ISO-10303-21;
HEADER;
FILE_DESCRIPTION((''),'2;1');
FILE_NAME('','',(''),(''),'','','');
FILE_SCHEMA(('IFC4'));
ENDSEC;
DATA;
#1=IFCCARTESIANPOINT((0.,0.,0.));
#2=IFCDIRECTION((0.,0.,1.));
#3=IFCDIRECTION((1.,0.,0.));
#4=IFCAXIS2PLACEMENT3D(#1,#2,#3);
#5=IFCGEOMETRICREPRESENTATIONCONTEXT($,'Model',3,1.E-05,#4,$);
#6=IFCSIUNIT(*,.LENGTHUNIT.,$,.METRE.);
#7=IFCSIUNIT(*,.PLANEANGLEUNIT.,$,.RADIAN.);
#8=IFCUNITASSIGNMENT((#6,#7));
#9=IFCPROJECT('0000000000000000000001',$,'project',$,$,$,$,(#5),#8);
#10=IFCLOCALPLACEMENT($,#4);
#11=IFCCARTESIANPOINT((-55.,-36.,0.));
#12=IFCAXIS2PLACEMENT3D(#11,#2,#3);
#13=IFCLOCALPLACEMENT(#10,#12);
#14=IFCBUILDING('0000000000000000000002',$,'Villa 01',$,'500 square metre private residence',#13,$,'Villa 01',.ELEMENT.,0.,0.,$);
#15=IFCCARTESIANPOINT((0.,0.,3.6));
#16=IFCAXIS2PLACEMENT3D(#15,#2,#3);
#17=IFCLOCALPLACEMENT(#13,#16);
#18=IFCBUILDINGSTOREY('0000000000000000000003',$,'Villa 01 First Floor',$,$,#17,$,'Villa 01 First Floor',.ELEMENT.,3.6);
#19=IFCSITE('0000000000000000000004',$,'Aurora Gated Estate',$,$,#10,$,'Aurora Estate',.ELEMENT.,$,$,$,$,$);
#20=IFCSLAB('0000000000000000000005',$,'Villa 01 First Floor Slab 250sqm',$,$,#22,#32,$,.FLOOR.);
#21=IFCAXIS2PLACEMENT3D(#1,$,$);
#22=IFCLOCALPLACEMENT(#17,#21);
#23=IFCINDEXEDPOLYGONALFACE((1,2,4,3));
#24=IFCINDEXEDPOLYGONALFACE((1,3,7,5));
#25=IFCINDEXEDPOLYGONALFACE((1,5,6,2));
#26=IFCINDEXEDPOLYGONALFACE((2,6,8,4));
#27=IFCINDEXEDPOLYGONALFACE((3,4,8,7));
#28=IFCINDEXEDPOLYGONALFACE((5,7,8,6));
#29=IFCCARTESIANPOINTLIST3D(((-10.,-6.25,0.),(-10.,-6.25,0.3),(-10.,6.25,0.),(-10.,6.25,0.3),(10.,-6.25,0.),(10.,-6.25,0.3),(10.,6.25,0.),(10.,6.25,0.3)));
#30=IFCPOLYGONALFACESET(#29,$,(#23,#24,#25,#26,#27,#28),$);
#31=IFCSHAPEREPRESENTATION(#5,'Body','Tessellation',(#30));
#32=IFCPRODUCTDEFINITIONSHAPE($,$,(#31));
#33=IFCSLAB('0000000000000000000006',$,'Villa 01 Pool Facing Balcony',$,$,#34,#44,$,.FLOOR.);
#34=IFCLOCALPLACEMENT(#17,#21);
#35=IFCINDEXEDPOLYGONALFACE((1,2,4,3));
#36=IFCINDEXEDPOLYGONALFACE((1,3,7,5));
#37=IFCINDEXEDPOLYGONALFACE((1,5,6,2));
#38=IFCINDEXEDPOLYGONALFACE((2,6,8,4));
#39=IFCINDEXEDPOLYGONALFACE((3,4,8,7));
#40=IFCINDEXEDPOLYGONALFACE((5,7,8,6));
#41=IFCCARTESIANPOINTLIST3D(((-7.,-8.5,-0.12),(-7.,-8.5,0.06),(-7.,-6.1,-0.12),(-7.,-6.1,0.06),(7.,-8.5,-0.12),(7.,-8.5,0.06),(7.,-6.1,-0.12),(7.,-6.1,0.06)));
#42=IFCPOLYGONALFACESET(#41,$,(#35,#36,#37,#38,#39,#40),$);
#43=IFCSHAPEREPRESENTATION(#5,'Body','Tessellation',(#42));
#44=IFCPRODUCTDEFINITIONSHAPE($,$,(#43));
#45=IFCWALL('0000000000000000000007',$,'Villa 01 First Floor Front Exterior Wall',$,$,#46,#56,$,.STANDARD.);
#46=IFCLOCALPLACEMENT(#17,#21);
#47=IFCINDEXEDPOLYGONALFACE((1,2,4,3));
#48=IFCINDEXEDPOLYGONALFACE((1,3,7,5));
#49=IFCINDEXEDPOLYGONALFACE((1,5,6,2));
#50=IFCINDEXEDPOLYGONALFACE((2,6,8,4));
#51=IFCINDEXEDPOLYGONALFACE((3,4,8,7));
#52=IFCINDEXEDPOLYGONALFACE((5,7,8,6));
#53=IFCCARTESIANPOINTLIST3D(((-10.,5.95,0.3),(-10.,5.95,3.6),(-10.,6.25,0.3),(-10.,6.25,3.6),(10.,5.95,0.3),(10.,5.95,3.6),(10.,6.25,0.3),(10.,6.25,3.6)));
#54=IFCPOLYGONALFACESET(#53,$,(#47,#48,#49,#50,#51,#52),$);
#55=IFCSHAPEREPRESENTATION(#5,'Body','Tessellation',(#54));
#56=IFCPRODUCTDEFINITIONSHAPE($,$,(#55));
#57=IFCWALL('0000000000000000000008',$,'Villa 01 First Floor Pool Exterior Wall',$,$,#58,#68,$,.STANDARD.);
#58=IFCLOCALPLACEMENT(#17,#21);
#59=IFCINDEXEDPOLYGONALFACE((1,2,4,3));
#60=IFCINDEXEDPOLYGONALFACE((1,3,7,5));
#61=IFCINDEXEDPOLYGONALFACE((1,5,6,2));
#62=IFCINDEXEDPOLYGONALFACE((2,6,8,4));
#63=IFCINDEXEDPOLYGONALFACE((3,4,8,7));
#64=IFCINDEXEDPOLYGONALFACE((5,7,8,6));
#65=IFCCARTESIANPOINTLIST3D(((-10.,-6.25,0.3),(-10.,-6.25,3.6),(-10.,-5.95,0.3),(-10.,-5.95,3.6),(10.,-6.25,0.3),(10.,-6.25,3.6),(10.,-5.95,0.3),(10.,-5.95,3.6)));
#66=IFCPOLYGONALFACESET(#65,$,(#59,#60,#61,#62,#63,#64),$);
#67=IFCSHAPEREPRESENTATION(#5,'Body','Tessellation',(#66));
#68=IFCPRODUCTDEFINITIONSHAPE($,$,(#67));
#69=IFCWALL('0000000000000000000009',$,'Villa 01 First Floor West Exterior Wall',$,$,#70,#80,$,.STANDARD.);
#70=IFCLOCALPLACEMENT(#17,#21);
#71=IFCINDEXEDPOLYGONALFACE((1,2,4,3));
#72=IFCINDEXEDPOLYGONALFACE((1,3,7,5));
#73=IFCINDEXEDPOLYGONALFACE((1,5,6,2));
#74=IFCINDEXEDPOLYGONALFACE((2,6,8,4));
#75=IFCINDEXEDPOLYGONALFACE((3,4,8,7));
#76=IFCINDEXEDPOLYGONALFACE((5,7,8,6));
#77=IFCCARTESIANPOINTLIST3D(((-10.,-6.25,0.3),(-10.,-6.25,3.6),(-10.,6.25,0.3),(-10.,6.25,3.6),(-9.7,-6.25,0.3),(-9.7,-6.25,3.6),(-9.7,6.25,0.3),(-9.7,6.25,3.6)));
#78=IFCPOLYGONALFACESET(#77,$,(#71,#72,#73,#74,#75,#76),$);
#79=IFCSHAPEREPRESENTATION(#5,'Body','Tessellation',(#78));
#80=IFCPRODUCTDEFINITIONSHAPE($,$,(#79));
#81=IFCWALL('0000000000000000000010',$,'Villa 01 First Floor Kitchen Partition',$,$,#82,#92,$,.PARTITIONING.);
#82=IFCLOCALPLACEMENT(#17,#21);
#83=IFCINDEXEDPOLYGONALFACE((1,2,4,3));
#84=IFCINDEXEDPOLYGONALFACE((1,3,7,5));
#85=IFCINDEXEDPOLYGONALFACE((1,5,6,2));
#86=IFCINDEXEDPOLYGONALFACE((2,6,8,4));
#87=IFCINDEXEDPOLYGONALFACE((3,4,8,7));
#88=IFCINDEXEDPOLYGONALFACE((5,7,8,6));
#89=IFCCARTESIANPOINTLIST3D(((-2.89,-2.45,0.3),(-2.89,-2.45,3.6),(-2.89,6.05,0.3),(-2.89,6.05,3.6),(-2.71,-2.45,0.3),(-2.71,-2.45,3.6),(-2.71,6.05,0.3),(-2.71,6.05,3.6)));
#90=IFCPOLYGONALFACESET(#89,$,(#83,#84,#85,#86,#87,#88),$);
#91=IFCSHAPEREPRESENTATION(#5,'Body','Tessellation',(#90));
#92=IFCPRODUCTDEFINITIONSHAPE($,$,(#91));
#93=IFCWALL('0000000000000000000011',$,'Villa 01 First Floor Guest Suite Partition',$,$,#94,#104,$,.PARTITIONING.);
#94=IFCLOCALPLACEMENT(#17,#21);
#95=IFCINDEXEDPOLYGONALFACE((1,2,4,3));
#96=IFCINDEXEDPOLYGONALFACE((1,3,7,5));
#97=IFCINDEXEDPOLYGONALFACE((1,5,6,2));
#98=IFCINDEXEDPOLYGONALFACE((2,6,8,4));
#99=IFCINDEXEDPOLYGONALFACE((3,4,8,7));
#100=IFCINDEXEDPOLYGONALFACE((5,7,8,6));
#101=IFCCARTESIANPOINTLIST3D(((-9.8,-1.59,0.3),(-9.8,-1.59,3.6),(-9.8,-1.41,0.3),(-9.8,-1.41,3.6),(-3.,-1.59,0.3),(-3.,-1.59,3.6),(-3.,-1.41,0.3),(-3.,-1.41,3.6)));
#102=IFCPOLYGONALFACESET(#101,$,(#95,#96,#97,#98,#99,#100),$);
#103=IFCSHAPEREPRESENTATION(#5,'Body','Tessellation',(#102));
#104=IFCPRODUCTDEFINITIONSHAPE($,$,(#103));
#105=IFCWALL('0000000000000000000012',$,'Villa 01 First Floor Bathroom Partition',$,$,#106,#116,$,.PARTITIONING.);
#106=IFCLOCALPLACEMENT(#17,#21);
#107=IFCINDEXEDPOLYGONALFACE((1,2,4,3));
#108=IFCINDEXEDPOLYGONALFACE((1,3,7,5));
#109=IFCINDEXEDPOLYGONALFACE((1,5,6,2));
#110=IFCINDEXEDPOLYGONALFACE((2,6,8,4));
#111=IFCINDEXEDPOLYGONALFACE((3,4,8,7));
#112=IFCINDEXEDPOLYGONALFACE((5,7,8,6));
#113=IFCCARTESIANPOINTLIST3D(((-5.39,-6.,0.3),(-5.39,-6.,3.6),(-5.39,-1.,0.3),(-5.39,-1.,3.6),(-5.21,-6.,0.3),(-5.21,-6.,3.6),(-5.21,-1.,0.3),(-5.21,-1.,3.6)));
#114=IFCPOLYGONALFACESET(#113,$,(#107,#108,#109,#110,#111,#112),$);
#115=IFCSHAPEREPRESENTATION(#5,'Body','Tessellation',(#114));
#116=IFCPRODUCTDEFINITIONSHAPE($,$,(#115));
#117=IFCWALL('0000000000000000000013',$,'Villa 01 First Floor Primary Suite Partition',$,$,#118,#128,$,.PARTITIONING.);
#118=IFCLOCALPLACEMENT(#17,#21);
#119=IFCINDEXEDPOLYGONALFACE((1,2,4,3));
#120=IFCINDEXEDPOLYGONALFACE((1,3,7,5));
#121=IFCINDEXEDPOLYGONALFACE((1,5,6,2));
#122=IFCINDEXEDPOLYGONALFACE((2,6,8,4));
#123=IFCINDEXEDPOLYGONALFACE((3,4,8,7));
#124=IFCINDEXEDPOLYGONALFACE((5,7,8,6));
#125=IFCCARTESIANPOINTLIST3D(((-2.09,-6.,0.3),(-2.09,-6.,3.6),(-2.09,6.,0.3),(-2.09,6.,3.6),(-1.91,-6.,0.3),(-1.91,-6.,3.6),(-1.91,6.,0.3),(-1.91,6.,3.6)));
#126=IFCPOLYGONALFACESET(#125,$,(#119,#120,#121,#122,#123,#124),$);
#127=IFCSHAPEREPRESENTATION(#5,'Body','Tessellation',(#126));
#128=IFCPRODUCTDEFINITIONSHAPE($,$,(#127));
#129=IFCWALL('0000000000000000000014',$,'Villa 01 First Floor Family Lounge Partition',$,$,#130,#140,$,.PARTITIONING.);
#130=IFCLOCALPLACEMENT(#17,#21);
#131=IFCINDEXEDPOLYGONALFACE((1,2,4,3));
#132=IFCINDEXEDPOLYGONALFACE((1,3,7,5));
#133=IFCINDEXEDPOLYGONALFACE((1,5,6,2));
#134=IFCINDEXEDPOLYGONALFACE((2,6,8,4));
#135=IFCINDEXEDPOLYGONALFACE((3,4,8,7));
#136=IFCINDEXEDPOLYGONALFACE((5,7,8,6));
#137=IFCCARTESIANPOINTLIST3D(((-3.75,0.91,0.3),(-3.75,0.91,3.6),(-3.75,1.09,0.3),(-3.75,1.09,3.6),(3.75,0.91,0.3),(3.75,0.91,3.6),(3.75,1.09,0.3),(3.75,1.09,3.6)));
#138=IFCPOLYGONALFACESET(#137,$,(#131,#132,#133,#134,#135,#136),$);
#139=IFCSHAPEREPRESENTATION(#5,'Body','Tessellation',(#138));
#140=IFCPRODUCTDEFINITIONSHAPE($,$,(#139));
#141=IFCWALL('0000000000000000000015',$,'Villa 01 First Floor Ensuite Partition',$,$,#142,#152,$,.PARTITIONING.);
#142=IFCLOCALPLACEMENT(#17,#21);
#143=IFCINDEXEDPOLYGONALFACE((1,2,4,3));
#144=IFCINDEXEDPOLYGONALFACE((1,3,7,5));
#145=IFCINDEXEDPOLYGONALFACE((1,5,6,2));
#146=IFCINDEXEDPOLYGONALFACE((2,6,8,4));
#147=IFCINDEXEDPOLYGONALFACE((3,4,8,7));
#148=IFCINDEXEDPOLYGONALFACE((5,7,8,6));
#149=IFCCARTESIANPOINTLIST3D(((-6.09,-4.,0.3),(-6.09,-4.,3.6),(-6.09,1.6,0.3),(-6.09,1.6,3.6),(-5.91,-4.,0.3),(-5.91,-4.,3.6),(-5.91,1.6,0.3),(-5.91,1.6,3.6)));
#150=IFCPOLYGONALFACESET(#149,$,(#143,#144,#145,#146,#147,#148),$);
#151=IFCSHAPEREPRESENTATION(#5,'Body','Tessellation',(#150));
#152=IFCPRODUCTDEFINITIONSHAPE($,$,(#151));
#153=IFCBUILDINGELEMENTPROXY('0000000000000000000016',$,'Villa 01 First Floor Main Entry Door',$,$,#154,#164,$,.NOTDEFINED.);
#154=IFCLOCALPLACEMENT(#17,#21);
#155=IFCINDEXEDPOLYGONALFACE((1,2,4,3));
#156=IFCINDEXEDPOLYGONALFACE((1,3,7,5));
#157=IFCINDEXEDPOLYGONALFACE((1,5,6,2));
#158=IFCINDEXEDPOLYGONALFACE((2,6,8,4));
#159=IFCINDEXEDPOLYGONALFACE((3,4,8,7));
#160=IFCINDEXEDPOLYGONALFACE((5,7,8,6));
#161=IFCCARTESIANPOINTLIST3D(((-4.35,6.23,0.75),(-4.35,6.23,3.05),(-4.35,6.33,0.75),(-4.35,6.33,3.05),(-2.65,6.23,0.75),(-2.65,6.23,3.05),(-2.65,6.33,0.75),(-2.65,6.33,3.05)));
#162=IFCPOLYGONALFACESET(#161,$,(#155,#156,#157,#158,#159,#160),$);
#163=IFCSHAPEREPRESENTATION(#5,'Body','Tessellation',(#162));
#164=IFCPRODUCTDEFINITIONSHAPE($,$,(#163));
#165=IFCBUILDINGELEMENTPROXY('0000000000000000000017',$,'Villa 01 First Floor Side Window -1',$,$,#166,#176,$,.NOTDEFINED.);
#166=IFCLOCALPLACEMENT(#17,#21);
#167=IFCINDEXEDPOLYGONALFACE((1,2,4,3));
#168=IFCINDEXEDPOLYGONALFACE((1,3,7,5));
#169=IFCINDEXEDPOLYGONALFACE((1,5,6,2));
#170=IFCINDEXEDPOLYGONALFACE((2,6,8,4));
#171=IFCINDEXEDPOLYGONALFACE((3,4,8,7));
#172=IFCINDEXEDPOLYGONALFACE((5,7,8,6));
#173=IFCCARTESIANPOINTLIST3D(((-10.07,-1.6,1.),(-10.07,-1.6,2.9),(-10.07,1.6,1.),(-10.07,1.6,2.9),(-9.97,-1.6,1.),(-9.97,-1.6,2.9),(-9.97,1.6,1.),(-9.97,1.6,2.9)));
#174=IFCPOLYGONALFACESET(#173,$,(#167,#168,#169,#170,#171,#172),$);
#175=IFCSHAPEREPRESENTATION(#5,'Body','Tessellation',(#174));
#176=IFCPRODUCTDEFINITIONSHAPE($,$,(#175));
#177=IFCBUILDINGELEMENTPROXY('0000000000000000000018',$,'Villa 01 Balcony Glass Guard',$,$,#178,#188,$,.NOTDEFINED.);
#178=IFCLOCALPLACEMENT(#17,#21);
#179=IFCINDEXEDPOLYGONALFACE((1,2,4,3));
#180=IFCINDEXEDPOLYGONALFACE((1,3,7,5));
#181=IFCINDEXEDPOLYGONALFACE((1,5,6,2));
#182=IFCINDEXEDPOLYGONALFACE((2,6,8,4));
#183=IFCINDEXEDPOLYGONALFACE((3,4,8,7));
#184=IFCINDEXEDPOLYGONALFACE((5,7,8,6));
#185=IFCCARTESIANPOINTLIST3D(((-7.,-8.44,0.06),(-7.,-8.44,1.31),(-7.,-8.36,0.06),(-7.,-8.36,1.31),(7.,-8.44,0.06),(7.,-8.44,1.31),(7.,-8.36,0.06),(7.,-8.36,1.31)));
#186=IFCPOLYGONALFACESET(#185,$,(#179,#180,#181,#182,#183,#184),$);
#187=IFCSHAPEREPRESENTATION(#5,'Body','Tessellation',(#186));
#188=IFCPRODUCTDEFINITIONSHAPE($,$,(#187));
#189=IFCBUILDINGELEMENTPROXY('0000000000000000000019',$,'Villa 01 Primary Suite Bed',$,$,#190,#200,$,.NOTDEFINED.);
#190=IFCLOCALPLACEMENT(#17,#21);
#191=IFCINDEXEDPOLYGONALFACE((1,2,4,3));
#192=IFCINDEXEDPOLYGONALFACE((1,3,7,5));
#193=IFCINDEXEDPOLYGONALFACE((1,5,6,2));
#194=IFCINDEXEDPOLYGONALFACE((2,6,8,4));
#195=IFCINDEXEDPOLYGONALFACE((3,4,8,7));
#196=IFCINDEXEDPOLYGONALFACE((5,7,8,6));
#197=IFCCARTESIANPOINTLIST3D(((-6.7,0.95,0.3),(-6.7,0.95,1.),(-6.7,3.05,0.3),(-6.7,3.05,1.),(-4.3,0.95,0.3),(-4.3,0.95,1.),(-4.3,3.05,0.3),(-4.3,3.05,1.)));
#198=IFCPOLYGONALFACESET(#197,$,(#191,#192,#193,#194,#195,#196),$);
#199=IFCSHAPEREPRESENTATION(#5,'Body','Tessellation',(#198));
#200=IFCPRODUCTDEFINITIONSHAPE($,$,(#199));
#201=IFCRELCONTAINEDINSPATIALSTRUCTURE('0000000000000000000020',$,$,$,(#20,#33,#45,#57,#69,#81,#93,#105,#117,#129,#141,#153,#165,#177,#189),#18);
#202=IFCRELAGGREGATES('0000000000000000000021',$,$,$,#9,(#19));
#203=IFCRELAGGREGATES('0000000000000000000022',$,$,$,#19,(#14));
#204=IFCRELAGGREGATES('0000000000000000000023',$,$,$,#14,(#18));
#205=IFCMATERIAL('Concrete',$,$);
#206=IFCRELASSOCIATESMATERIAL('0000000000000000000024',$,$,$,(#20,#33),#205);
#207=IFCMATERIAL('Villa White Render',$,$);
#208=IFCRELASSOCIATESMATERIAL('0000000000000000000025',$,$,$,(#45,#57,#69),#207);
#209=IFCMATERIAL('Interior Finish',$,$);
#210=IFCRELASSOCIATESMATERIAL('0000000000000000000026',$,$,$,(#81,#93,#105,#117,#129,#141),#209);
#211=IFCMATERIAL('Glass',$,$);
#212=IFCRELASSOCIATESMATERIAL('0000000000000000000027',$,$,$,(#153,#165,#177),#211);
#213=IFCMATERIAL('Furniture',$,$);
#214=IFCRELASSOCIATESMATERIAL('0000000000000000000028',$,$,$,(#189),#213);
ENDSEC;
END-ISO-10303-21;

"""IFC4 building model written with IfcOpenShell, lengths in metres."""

from ifc_helpers import new_model, si_unit, frame, origin_with_axes, origin_2d_with_axis, place, context, project, spatial, rectangle, extrude, material, element, save


model = new_model("IFC4")

# Units and contexts
model_context = context("Model", 3, precision=1e-05, world=origin_with_axes())
ifc_project = project(units=[si_unit("LENGTHUNIT", "METRE"), si_unit("PLANEANGLEUNIT", "RADIAN")], contexts=[model_context])

# Site, building, storey
site_placement = place(None, origin_with_axes())
site = spatial("IfcSite", under=ifc_project, at=site_placement, Name="Aurora Gated Estate", LongName="Aurora Estate", CompositionType="ELEMENT")
building_placement = place(site_placement, frame((-55.0, -36.0, 0.0), z_axis=(0.0, 0.0, 1.0), x_axis=(1.0, 0.0, 0.0)))
building = spatial("IfcBuilding", under=site, at=building_placement, Name="Villa 01", ObjectType="500 square metre private residence", LongName="Villa 01", CompositionType="ELEMENT", ElevationOfRefHeight=0.0, ElevationOfTerrain=0.0)
storey_placement = place(building_placement, frame((0.0, 0.0, 3.6), z_axis=(0.0, 0.0, 1.0), x_axis=(1.0, 0.0, 0.0)))
storey = spatial("IfcBuildingStorey", under=building, at=storey_placement, Name="Villa 01 First Floor", LongName="Villa 01 First Floor", CompositionType="ELEMENT", Elevation=3.6)

# Slabs
ifc_material_1 = material(Name="Concrete")
slab_1_placement = place(storey_placement, origin_with_axes())
element("IfcSlab", 1, at=slab_1_placement, inside=storey, material=ifc_material_1, Name="Villa 01 First Floor Slab 250sqm", PredefinedType="FLOOR", context=model_context, shape_type="SweptSolid", body=[
    extrude(rectangle(XDim=20.0, YDim=12.5, at=origin_2d_with_axis()), origin_with_axes(), (0.0, 0.0, 1.0), 0.3),
])
slab_2_placement = place(storey_placement, frame((0.0, -7.3, -0.12), z_axis=(0.0, 0.0, 1.0), x_axis=(1.0, 0.0, 0.0)))
element("IfcSlab", 2, at=slab_2_placement, inside=storey, material=ifc_material_1, Name="Villa 01 Pool Facing Balcony", PredefinedType="FLOOR", context=model_context, shape_type="SweptSolid", body=[
    extrude(rectangle(XDim=14.0, YDim=2.4, at=origin_2d_with_axis()), origin_with_axes(), (0.0, 0.0, 1.0), 0.18),
])

# Walls
ifc_material_2 = material(Name="Villa White Render")
for number, where, z_axis, x_axis, name in (
    (3, (0.0, 6.1, 0.3), (0.0, 0.0, 1.0), (1.0, 0.0, 0.0), "Villa 01 First Floor Front Exterior Wall"),
    (4, (0.0, -6.1, 0.3), (0.0, 0.0, 1.0), (1.0, 0.0, 0.0), "Villa 01 First Floor Pool Exterior Wall"),
):
    element("IfcWall", number, at=place(storey_placement, frame(where, z_axis=z_axis, x_axis=x_axis)), inside=storey, material=ifc_material_2, Name=name, PredefinedType="STANDARD", context=model_context, shape_type="SweptSolid", body=[
        extrude(rectangle(XDim=20.0, YDim=0.3, at=origin_2d_with_axis()), origin_with_axes(), (0.0, 0.0, 1.0), 3.3),
    ])
wall_1_placement = place(storey_placement, frame((-9.85, 0.0, 0.3), z_axis=(0.0, 0.0, 1.0), x_axis=(1.0, 0.0, 0.0)))
element("IfcWall", 5, at=wall_1_placement, inside=storey, material=ifc_material_2, Name="Villa 01 First Floor West Exterior Wall", PredefinedType="STANDARD", context=model_context, shape_type="SweptSolid", body=[
    extrude(rectangle(XDim=0.3, YDim=12.5, at=origin_2d_with_axis()), origin_with_axes(), (0.0, 0.0, 1.0), 3.3),
])
ifc_material_3 = material(Name="Interior Finish")
wall_2_placement = place(storey_placement, frame((-2.8, 1.8, 0.3), z_axis=(0.0, 0.0, 1.0), x_axis=(1.0, 0.0, 0.0)))
element("IfcWall", 6, at=wall_2_placement, inside=storey, material=ifc_material_3, Name="Villa 01 First Floor Kitchen Partition", PredefinedType="PARTITIONING", context=model_context, shape_type="SweptSolid", body=[
    extrude(rectangle(XDim=0.18, YDim=8.5, at=origin_2d_with_axis()), origin_with_axes(), (0.0, 0.0, 1.0), 3.3),
])
wall_3_placement = place(storey_placement, frame((-6.4, -1.5, 0.3), z_axis=(0.0, 0.0, 1.0), x_axis=(1.0, 0.0, 0.0)))
element("IfcWall", 7, at=wall_3_placement, inside=storey, material=ifc_material_3, Name="Villa 01 First Floor Guest Suite Partition", PredefinedType="PARTITIONING", context=model_context, shape_type="SweptSolid", body=[
    extrude(rectangle(XDim=6.8, YDim=0.18, at=origin_2d_with_axis()), origin_with_axes(), (0.0, 0.0, 1.0), 3.3),
])
wall_4_placement = place(storey_placement, frame((-5.3, -3.5, 0.3), z_axis=(0.0, 0.0, 1.0), x_axis=(1.0, 0.0, 0.0)))
element("IfcWall", 8, at=wall_4_placement, inside=storey, material=ifc_material_3, Name="Villa 01 First Floor Bathroom Partition", PredefinedType="PARTITIONING", context=model_context, shape_type="SweptSolid", body=[
    extrude(rectangle(XDim=0.18, YDim=5.0, at=origin_2d_with_axis()), origin_with_axes(), (0.0, 0.0, 1.0), 3.3),
])
wall_5_placement = place(storey_placement, frame((-2.0, 0.0, 0.3), z_axis=(0.0, 0.0, 1.0), x_axis=(1.0, 0.0, 0.0)))
element("IfcWall", 9, at=wall_5_placement, inside=storey, material=ifc_material_3, Name="Villa 01 First Floor Primary Suite Partition", PredefinedType="PARTITIONING", context=model_context, shape_type="SweptSolid", body=[
    extrude(rectangle(XDim=0.18, YDim=12.0, at=origin_2d_with_axis()), origin_with_axes(), (0.0, 0.0, 1.0), 3.3),
])
wall_6_placement = place(storey_placement, frame((0.0, 1.0, 0.3), z_axis=(0.0, 0.0, 1.0), x_axis=(1.0, 0.0, 0.0)))
element("IfcWall", 10, at=wall_6_placement, inside=storey, material=ifc_material_3, Name="Villa 01 First Floor Family Lounge Partition", PredefinedType="PARTITIONING", context=model_context, shape_type="SweptSolid", body=[
    extrude(rectangle(XDim=7.5, YDim=0.18, at=origin_2d_with_axis()), origin_with_axes(), (0.0, 0.0, 1.0), 3.3),
])
wall_7_placement = place(storey_placement, frame((-6.0, -1.2, 0.3), z_axis=(0.0, 0.0, 1.0), x_axis=(1.0, 0.0, 0.0)))
element("IfcWall", 11, at=wall_7_placement, inside=storey, material=ifc_material_3, Name="Villa 01 First Floor Ensuite Partition", PredefinedType="PARTITIONING", context=model_context, shape_type="SweptSolid", body=[
    extrude(rectangle(XDim=0.18, YDim=5.6, at=origin_2d_with_axis()), origin_with_axes(), (0.0, 0.0, 1.0), 3.3),
])

# Building element proxies
ifc_material_4 = material(Name="Glass")
proxy_1_placement = place(storey_placement, frame((-3.5, 6.28, 0.75), z_axis=(0.0, 0.0, 1.0), x_axis=(1.0, 0.0, 0.0)))
element("IfcBuildingElementProxy", 12, at=proxy_1_placement, inside=storey, material=ifc_material_4, Name="Villa 01 First Floor Main Entry Door", PredefinedType="NOTDEFINED", context=model_context, shape_type="SweptSolid", body=[
    extrude(rectangle(XDim=1.7, YDim=0.1, at=origin_2d_with_axis()), origin_with_axes(), (0.0, 0.0, 1.0), 2.3),
])
proxy_2_placement = place(storey_placement, frame((-10.02, 0.0, 1.0), z_axis=(0.0, 0.0, 1.0), x_axis=(0.0, 1.0, 0.0)))
element("IfcBuildingElementProxy", 13, at=proxy_2_placement, inside=storey, material=ifc_material_4, Name="Villa 01 First Floor Side Window -1", PredefinedType="NOTDEFINED", context=model_context, shape_type="SweptSolid", body=[
    extrude(rectangle(XDim=3.2, YDim=0.1, at=origin_2d_with_axis()), origin_with_axes(), (0.0, 0.0, 1.0), 1.9),
])
proxy_3_placement = place(storey_placement, frame((0.0, -8.4, 0.06), z_axis=(0.0, 0.0, 1.0), x_axis=(1.0, 0.0, 0.0)))
element("IfcBuildingElementProxy", 14, at=proxy_3_placement, inside=storey, material=ifc_material_4, Name="Villa 01 Balcony Glass Guard", PredefinedType="NOTDEFINED", context=model_context, shape_type="SweptSolid", body=[
    extrude(rectangle(XDim=14.0, YDim=0.08, at=origin_2d_with_axis()), origin_with_axes(), (0.0, 0.0, 1.0), 1.25),
])
ifc_material_5 = material(Name="Furniture")
proxy_4_placement = place(storey_placement, frame((-5.5, 2.0, 0.3), z_axis=(0.0, 0.0, 1.0), x_axis=(1.0, 0.0, 0.0)))
element("IfcBuildingElementProxy", 15, at=proxy_4_placement, inside=storey, material=ifc_material_5, Name="Villa 01 Primary Suite Bed", PredefinedType="NOTDEFINED", context=model_context, shape_type="SweptSolid", body=[
    extrude(rectangle(XDim=2.4, YDim=2.1, at=origin_2d_with_axis()), origin_with_axes(), (0.0, 0.0, 1.0), 0.7),
])

save(model, "model.ifc")
